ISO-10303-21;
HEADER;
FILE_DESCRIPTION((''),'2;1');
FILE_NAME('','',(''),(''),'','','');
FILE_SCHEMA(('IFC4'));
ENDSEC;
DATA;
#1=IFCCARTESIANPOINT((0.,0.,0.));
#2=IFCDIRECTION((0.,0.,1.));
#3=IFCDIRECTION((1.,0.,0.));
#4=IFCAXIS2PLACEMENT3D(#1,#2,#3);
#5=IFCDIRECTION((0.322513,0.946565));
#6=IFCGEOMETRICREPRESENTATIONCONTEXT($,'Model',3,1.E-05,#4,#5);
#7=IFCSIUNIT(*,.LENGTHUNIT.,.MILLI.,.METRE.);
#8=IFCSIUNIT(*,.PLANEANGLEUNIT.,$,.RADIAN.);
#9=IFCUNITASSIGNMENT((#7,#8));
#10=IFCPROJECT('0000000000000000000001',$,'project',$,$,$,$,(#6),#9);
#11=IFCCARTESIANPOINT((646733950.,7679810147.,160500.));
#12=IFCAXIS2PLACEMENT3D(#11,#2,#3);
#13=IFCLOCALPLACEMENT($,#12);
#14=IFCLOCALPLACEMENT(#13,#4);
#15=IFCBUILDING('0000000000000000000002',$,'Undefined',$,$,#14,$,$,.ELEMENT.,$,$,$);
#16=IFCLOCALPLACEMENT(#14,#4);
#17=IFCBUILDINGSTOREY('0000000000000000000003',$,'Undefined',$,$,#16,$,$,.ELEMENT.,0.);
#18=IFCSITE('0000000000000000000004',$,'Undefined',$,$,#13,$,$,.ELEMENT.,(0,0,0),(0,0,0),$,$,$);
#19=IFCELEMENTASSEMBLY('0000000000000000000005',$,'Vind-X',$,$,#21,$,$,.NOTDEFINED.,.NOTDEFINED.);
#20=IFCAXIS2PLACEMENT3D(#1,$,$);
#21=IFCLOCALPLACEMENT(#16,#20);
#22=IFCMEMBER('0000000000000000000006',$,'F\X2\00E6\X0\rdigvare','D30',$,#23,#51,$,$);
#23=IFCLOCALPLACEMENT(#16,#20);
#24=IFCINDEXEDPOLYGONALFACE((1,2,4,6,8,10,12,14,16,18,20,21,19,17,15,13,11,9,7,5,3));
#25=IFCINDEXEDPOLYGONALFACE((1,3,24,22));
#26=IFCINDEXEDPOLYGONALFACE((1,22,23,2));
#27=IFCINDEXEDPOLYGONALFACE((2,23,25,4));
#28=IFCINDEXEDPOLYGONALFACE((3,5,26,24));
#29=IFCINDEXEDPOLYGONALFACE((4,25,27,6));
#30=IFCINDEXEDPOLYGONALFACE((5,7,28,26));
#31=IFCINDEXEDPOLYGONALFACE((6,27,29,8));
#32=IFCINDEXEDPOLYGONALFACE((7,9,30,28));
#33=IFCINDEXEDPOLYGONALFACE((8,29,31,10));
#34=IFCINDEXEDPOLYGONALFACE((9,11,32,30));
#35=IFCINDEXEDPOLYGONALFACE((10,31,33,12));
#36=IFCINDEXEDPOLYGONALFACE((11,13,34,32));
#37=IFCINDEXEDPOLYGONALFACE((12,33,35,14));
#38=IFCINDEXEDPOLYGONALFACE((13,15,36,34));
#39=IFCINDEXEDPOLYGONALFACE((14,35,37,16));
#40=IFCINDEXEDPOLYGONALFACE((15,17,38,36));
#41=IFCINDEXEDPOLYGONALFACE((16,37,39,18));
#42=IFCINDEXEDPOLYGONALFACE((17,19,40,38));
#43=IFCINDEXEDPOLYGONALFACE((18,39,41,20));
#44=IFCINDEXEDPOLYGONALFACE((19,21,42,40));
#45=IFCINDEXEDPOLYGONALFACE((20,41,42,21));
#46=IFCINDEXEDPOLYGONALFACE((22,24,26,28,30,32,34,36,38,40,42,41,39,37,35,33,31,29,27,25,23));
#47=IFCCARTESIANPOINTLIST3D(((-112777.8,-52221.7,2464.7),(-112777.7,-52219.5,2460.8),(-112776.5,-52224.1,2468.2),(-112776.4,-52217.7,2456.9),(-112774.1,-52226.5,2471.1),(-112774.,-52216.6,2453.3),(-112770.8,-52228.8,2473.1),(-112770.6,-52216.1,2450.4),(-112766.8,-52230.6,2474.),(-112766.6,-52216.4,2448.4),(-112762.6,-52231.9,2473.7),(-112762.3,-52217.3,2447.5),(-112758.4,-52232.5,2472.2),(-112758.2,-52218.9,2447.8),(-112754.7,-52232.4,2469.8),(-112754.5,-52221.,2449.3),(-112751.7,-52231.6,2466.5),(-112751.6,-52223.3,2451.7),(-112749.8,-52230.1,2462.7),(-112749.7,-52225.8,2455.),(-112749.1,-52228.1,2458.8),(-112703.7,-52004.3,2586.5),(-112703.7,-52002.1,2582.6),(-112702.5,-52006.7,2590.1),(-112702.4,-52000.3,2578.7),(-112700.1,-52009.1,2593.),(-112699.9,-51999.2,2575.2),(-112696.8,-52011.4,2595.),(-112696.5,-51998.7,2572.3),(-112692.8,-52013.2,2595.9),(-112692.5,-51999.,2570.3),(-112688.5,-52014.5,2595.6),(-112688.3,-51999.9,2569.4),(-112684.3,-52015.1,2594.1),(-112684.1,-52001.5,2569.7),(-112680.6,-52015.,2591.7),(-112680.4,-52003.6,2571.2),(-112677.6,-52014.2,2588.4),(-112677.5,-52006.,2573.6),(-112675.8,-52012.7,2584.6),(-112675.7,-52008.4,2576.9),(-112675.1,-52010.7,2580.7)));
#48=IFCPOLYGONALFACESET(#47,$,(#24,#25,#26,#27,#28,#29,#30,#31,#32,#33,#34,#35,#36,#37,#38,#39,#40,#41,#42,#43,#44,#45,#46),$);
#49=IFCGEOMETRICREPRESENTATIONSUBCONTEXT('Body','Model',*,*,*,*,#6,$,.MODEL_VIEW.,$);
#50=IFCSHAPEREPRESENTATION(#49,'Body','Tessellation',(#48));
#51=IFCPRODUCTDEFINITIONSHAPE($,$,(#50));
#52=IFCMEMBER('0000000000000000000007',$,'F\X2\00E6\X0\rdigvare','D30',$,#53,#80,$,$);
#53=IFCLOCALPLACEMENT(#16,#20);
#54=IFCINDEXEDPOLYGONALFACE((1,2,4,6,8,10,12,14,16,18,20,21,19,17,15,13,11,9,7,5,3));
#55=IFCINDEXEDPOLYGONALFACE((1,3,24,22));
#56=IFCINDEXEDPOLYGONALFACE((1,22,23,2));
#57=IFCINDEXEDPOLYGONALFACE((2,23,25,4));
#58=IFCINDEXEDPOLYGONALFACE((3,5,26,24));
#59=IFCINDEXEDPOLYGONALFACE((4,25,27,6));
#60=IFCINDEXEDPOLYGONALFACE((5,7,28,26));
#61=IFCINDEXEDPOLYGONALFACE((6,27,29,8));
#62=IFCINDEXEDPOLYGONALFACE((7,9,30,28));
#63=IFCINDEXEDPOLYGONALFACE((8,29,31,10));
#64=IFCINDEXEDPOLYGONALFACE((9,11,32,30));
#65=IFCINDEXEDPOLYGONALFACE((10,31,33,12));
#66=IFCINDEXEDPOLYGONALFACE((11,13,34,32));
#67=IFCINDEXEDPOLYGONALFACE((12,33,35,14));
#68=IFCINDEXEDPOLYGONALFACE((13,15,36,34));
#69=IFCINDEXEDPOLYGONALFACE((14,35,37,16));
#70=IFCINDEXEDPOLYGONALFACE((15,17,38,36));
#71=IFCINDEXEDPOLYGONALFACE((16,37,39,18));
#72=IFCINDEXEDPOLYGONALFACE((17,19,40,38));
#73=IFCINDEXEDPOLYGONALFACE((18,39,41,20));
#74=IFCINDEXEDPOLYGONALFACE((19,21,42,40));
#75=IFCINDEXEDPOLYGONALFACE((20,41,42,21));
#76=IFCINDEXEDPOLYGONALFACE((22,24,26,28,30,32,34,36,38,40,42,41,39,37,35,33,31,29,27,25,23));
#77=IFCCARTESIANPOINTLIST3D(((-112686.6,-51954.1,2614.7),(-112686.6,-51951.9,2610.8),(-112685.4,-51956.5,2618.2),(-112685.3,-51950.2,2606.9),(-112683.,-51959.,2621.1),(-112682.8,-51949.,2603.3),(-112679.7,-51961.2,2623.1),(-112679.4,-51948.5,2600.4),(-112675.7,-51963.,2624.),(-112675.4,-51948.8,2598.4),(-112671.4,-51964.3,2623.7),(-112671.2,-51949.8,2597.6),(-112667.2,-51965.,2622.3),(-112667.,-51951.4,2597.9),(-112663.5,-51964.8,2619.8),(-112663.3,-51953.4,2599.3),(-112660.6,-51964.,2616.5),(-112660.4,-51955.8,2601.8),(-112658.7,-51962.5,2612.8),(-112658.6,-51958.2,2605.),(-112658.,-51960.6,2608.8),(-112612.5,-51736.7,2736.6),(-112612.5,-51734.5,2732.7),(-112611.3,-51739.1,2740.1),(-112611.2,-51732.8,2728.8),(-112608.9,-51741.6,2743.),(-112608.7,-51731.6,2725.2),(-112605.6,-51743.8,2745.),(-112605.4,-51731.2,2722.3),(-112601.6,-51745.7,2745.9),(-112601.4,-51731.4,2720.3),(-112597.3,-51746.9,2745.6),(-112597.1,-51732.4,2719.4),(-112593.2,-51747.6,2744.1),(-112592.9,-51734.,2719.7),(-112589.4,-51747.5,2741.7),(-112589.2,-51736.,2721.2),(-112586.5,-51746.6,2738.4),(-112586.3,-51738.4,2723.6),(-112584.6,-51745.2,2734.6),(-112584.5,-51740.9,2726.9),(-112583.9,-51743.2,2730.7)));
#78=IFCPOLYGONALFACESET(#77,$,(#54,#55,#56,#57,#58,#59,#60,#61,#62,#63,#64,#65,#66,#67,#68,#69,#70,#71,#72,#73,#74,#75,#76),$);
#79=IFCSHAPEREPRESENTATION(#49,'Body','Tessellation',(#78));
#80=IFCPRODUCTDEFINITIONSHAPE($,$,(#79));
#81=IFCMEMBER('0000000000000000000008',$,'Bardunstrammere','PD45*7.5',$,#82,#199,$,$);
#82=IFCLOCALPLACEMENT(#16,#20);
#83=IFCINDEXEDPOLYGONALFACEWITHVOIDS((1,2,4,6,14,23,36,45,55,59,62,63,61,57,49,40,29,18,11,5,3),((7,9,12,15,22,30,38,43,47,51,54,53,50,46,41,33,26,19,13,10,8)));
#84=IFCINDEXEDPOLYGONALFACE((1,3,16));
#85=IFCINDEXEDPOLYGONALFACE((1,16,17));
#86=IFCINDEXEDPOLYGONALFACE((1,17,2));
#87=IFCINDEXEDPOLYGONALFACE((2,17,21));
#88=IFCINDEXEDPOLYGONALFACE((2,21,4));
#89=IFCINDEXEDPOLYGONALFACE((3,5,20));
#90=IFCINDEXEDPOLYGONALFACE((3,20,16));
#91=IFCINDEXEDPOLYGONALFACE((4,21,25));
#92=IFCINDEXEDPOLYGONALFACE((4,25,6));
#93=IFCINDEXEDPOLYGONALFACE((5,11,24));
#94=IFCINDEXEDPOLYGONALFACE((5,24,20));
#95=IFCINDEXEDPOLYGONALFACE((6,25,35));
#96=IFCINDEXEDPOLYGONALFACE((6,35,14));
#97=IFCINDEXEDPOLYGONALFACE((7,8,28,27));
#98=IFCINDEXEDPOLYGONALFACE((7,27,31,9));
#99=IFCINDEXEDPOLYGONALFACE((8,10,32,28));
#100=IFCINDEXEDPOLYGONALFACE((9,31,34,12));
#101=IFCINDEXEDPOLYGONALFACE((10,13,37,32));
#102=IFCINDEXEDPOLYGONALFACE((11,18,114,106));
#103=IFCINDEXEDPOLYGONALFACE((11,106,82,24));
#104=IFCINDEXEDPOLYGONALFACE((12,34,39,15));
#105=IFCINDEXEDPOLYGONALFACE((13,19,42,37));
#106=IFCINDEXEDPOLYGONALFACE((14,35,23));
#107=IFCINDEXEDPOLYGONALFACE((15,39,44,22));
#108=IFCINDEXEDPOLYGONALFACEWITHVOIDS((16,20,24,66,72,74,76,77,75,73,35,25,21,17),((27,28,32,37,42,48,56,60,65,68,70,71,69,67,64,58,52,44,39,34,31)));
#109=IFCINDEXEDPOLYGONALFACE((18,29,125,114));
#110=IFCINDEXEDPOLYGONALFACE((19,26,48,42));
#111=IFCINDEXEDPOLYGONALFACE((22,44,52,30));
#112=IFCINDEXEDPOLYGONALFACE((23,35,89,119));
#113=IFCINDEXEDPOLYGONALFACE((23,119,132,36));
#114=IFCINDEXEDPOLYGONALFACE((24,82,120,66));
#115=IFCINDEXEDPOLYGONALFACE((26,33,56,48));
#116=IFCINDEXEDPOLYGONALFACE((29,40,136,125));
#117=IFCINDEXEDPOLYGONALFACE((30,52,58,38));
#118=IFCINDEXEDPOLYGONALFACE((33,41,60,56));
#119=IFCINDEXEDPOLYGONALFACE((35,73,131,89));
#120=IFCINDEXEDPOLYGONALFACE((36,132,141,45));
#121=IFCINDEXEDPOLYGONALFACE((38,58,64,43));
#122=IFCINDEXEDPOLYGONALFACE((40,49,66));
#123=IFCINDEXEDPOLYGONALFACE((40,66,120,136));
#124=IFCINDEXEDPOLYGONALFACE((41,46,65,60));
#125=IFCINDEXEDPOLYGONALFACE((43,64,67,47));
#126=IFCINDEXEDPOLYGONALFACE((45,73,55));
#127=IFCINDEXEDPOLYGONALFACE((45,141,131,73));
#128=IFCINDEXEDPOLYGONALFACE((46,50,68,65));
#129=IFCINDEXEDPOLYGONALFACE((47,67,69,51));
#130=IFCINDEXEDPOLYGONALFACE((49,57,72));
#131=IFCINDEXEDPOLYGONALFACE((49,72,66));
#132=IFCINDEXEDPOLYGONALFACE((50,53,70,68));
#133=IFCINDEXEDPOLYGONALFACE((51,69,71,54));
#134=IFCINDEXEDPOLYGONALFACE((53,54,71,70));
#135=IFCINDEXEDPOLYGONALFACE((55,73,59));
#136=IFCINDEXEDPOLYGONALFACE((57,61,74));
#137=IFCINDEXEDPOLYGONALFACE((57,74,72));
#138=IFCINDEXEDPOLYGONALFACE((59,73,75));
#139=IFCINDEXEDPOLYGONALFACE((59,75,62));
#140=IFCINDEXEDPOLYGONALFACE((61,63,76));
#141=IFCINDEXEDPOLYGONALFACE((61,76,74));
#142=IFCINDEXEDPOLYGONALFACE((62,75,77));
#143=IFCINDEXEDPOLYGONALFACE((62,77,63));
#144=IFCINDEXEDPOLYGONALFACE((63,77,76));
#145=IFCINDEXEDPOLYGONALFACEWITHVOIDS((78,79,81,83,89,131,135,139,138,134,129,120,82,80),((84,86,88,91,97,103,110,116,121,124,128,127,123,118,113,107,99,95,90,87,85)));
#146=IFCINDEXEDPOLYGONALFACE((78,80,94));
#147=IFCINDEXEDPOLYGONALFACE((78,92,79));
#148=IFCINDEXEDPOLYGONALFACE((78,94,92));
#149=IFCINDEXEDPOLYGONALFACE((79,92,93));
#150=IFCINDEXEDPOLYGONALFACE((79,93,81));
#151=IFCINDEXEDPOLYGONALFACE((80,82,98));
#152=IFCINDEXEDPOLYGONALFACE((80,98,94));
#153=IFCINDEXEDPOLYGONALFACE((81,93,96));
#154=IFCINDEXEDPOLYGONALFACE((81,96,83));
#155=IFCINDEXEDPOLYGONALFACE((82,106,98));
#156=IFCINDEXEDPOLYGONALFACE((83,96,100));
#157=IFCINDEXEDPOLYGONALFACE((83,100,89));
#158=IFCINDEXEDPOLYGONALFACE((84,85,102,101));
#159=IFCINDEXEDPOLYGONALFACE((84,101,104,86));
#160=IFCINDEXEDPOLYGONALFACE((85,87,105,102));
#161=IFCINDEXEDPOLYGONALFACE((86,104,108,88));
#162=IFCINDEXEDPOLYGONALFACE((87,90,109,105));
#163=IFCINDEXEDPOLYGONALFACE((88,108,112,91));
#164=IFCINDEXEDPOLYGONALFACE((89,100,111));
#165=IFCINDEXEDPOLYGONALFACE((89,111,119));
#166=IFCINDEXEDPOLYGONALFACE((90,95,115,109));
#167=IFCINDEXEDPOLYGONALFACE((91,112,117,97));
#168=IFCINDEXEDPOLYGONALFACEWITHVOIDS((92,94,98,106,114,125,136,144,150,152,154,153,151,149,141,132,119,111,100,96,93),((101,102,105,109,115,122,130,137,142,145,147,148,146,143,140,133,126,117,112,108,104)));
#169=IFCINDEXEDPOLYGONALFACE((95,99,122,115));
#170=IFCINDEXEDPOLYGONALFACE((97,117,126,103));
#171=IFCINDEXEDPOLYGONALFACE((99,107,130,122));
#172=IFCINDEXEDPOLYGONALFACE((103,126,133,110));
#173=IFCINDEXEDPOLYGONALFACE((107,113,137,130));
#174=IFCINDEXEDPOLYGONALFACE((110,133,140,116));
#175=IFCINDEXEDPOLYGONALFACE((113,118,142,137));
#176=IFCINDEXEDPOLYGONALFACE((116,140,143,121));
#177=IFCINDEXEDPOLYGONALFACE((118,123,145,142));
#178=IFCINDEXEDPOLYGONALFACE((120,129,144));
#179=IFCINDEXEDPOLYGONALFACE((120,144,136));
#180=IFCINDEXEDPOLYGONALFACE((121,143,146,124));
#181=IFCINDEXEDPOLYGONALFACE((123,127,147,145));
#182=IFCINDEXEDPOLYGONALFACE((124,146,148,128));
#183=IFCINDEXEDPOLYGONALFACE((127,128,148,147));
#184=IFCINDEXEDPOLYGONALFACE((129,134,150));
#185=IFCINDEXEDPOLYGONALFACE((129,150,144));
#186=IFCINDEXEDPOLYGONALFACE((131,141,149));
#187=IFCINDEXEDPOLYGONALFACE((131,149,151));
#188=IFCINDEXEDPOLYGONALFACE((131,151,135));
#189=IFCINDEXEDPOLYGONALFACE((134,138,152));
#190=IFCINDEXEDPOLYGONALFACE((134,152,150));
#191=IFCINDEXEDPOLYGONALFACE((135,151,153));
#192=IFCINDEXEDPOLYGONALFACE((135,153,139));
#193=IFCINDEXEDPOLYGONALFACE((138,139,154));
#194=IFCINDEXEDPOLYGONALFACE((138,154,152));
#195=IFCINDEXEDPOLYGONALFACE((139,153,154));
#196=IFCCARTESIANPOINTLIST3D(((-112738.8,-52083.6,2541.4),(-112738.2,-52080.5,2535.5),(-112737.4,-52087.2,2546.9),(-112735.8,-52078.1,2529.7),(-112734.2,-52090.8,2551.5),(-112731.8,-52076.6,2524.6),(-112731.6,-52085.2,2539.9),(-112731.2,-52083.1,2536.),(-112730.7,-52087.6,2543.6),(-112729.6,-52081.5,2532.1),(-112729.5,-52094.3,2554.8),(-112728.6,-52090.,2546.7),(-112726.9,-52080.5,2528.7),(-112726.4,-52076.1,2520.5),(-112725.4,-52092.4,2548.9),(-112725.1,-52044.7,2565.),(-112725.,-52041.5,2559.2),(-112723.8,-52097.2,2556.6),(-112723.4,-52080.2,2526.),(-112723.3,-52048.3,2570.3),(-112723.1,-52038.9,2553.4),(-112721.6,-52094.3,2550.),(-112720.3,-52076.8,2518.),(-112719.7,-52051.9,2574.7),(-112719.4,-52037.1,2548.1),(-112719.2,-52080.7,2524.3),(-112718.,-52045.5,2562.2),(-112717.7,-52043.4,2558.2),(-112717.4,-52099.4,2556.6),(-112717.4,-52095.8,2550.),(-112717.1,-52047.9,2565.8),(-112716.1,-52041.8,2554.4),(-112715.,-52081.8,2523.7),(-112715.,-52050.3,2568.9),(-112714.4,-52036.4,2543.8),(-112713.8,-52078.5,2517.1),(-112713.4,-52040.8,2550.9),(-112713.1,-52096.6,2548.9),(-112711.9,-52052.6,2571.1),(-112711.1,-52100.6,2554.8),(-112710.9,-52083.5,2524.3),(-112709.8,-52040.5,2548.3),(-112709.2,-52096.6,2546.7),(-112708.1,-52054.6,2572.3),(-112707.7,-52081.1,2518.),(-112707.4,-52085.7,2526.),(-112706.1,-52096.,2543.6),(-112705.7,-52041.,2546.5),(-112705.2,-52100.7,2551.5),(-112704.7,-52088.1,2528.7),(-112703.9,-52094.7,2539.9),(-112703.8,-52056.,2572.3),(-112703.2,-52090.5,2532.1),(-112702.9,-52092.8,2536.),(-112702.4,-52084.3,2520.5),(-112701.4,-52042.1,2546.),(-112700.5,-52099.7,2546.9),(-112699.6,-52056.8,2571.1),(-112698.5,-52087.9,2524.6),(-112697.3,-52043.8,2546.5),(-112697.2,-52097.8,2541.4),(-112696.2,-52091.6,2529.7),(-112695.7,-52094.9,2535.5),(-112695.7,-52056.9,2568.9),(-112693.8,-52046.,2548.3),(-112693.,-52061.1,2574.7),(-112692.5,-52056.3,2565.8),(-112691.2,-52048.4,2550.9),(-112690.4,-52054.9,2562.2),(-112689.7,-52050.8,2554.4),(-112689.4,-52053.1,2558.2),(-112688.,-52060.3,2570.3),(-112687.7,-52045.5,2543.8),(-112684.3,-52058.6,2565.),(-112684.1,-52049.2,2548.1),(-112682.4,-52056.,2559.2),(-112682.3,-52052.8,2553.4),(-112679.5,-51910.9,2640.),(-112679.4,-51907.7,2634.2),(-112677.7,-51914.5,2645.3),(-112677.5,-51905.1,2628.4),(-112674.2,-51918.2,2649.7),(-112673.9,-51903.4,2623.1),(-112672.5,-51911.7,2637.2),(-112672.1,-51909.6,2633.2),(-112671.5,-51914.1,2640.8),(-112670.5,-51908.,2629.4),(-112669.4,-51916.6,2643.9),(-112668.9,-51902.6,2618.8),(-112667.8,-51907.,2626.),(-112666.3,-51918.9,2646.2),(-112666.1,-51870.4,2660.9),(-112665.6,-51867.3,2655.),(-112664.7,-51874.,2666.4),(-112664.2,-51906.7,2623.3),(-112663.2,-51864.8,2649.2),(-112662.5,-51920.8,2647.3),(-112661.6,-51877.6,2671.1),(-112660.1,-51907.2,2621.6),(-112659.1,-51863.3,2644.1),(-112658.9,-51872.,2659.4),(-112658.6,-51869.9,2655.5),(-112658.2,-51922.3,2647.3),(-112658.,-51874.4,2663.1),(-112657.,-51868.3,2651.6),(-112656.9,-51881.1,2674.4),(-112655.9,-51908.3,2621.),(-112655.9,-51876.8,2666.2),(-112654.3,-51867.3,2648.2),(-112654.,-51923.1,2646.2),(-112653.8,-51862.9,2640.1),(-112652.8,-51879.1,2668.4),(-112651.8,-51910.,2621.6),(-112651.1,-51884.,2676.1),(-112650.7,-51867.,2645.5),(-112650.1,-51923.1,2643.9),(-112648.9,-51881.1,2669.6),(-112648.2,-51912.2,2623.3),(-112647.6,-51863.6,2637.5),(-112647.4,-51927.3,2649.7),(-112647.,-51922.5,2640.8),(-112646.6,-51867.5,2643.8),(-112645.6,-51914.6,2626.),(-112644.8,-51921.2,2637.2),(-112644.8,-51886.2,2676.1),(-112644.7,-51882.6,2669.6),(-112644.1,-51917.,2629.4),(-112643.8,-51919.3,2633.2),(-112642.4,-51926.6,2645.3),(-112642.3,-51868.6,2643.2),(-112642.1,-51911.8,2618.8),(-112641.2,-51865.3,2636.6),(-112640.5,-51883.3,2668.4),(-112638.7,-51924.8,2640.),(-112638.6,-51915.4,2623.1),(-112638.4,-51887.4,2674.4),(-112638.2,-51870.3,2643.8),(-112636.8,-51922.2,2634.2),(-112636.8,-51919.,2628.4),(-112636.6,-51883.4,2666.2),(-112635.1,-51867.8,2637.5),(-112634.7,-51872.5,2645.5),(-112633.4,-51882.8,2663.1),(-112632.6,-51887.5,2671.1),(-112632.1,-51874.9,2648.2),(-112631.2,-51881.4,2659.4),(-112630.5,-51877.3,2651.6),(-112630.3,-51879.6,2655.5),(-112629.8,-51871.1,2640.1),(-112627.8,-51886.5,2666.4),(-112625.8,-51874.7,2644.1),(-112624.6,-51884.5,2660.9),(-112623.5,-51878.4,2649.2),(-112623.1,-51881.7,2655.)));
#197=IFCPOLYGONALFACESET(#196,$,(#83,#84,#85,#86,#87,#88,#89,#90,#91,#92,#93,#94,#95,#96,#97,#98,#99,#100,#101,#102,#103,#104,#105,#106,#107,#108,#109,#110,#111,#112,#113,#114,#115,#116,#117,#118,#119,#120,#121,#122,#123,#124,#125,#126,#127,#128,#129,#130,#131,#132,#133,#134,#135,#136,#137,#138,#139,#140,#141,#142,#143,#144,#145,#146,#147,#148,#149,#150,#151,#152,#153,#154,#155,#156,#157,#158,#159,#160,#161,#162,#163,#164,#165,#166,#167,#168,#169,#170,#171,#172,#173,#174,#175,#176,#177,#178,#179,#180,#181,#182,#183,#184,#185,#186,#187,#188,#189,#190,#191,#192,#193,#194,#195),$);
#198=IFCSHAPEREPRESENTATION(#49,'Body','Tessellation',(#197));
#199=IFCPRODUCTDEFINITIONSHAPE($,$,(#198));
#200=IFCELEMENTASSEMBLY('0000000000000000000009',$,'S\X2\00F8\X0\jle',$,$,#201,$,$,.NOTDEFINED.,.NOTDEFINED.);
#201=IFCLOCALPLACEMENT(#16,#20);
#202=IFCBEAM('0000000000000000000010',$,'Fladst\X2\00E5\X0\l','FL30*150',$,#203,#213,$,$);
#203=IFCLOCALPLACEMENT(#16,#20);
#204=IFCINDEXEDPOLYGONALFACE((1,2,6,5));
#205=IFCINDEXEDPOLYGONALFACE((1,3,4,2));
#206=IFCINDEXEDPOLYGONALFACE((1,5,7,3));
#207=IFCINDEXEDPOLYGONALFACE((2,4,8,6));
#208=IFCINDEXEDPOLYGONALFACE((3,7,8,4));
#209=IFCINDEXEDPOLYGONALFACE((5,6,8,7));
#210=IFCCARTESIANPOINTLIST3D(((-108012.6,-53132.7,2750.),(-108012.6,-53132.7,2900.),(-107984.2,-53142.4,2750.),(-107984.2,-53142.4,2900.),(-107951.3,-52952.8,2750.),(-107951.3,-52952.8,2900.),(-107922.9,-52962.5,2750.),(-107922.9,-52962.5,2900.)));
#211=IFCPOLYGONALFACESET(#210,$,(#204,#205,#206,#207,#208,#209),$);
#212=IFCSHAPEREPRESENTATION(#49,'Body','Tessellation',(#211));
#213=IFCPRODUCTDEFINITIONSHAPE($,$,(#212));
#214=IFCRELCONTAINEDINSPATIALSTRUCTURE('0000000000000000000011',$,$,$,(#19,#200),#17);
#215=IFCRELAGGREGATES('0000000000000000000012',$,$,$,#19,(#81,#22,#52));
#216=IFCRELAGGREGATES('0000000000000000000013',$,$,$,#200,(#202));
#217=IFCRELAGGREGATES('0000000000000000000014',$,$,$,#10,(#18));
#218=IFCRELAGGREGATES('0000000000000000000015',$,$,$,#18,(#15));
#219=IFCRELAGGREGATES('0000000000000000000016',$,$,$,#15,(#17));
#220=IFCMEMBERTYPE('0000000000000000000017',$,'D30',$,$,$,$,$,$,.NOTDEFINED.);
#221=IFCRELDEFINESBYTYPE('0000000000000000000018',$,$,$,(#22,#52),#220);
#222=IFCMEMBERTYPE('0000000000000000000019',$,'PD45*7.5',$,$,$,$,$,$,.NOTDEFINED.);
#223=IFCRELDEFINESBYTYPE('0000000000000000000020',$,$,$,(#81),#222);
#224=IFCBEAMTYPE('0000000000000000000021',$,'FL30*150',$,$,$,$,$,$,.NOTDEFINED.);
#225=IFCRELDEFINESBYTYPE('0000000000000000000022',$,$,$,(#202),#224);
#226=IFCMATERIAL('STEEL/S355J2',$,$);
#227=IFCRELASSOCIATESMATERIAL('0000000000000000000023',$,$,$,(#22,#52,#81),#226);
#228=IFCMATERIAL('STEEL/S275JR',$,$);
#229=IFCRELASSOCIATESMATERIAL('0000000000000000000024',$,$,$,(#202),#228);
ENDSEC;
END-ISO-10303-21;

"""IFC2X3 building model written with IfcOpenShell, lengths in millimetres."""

from ifc_helpers import new_model, si_unit, direction, frame, origin_with_axes, origin_2d_with_axis, place, context, subcontext, project, spatial, rectangle, circle, hollow_circle, extrude, boolean, material, type_object, element, aggregate, save


model = new_model("IFC2X3")

# Units and contexts
model_context = context("Model", 3, precision=1e-05, world=origin_with_axes(), true_north=direction((0.322513, 0.946565)))
body_context = subcontext(model_context, "Body", "Model", "MODEL_VIEW")
ifc_project = project(units=[si_unit("LENGTHUNIT", "METRE", prefix="MILLI"), si_unit("PLANEANGLEUNIT", "RADIAN")], contexts=[model_context])

# Site, building, storey
site_placement = place(None, frame((646733950.0, 7679810147.0, 160500.0), z_axis=(0.0, 0.0, 1.0), x_axis=(1.0, 0.0, 0.0)))
site = spatial("IfcSite", under=ifc_project, at=site_placement, Name="Undefined", CompositionType="ELEMENT", RefLatitude=(0, 0, 0), RefLongitude=(0, 0, 0))
building_placement = place(site_placement, origin_with_axes())
building = spatial("IfcBuilding", under=site, at=building_placement, Name="Undefined", CompositionType="ELEMENT")
storey_placement = place(building_placement, origin_with_axes())
storey = spatial("IfcBuildingStorey", under=building, at=storey_placement, Name="Undefined", CompositionType="ELEMENT", Elevation=0.0)

# Element assembly, members
assembly_1_placement = place(storey_placement, origin_with_axes())
assembly_1 = element("IfcElementAssembly", 1, at=assembly_1_placement, inside=storey, Name="Vind-X", AssemblyPlace="NOTDEFINED", PredefinedType="NOTDEFINED")
ifc_material_1 = material(Name="STEEL/S355J2")
member_type_1 = type_object("IfcMemberType", Name="D30", PredefinedType="NOTDEFINED")
member_1_placement = place(assembly_1_placement, frame((-112689.5, -52006.9, 2582.6), z_axis=(-0.151189, -0.443734, 0.883313), x_axis=(-0.28488, -0.836113, -0.468783)))
member_1 = element("IfcMember", 2, at=member_1_placement, type_object=member_type_1, material=ifc_material_1, Name="Færdigvare", Description="D30", context=body_context, shape_type="SweptSolid", body=[
    extrude(circle(Radius=15.0, at=origin_2d_with_axis()), frame((260.0, 0.0, 0.0), z_axis=(-1.0, 0.0, 0.0), x_axis=(0.0, -1.0, 0.0)), (0.0, 0.0, 1.0), 260.0),
])
member_2_placement = place(assembly_1_placement, frame((-112598.3, -51739.4, 2732.7), z_axis=(-0.151189, -0.443735, 0.883313), x_axis=(-0.28488, -0.836113, -0.468784)))
member_2 = element("IfcMember", 3, at=member_2_placement, type_object=member_type_1, material=ifc_material_1, Name="Færdigvare", Description="D30", context=body_context, shape_type="SweptSolid", body=[
    extrude(circle(Radius=15.0, at=origin_2d_with_axis()), frame((260.0, 0.0, 0.0), z_axis=(-1.0, 0.0, 0.0), x_axis=(0.0, -1.0, 0.0)), (0.0, 0.0, 1.0), 260.0),
])
member_type_2 = type_object("IfcMemberType", Name="PD45*7.5", PredefinedType="NOTDEFINED")
member_3_placement = place(assembly_1_placement, frame((-112644.6, -51875.2, 2656.5), z_axis=(-0.946565, 0.322513, 0.0), x_axis=(-0.28488, -0.836113, -0.468784)))
member_3 = element("IfcMember", 4, at=member_3_placement, type_object=member_type_2, material=ifc_material_1, Name="Bardunstrammere", Description="PD45*7.5", context=body_context, shape_type="CSG", body=[
    boolean("DIFFERENCE", extrude(hollow_circle(Radius=22.5, WallThickness=7.5, at=origin_2d_with_axis()), frame((255.0, 0.0, 0.0), z_axis=(-1.0, 0.0, 0.0), x_axis=(0.0, -1.0, 0.0)), (0.0, 0.0, 1.0), 255.0), extrude(rectangle(XDim=35.0, YDim=90.0, at=origin_2d_with_axis()), frame((207.5, 0.0, 0.0), z_axis=(-1.0, 0.0, 0.0), x_axis=(0.0, -1.0, 0.0)), (0.0, 0.0, 1.0), 160.0)),
])

# Element assembly, beam
assembly_2_placement = place(storey_placement, origin_with_axes())
assembly_2 = element("IfcElementAssembly", 5, at=assembly_2_placement, inside=storey, Name="Søjle", AssemblyPlace="NOTDEFINED", PredefinedType="NOTDEFINED")
ifc_material_2 = material(Name="STEEL/S275JR")
beam_type_1 = type_object("IfcBeamType", Name="FL30*150", PredefinedType="NOTDEFINED")
beam_1_placement = place(assembly_2_placement, frame((-107967.8, -53047.6, 2900.0), z_axis=(-0.322513, -0.946565, 0.0), x_axis=(0.0, 0.0, -1.0)))
beam_1 = element("IfcBeam", 6, at=beam_1_placement, type_object=beam_type_1, material=ifc_material_2, Name="Fladstål", Description="FL30*150", context=body_context, shape_type="SweptSolid", body=[
    extrude(rectangle(XDim=30.0, YDim=190.0, at=origin_2d_with_axis()), frame((150.0, 0.0, 0.0), z_axis=(-1.0, 0.0, 0.0), x_axis=(0.0, -1.0, 0.0)), (0.0, 0.0, 1.0), 150.0),
])

aggregate(assembly_1, [member_3, member_1, member_2])
aggregate(assembly_2, [beam_1])

save(model, "model.ifc")
